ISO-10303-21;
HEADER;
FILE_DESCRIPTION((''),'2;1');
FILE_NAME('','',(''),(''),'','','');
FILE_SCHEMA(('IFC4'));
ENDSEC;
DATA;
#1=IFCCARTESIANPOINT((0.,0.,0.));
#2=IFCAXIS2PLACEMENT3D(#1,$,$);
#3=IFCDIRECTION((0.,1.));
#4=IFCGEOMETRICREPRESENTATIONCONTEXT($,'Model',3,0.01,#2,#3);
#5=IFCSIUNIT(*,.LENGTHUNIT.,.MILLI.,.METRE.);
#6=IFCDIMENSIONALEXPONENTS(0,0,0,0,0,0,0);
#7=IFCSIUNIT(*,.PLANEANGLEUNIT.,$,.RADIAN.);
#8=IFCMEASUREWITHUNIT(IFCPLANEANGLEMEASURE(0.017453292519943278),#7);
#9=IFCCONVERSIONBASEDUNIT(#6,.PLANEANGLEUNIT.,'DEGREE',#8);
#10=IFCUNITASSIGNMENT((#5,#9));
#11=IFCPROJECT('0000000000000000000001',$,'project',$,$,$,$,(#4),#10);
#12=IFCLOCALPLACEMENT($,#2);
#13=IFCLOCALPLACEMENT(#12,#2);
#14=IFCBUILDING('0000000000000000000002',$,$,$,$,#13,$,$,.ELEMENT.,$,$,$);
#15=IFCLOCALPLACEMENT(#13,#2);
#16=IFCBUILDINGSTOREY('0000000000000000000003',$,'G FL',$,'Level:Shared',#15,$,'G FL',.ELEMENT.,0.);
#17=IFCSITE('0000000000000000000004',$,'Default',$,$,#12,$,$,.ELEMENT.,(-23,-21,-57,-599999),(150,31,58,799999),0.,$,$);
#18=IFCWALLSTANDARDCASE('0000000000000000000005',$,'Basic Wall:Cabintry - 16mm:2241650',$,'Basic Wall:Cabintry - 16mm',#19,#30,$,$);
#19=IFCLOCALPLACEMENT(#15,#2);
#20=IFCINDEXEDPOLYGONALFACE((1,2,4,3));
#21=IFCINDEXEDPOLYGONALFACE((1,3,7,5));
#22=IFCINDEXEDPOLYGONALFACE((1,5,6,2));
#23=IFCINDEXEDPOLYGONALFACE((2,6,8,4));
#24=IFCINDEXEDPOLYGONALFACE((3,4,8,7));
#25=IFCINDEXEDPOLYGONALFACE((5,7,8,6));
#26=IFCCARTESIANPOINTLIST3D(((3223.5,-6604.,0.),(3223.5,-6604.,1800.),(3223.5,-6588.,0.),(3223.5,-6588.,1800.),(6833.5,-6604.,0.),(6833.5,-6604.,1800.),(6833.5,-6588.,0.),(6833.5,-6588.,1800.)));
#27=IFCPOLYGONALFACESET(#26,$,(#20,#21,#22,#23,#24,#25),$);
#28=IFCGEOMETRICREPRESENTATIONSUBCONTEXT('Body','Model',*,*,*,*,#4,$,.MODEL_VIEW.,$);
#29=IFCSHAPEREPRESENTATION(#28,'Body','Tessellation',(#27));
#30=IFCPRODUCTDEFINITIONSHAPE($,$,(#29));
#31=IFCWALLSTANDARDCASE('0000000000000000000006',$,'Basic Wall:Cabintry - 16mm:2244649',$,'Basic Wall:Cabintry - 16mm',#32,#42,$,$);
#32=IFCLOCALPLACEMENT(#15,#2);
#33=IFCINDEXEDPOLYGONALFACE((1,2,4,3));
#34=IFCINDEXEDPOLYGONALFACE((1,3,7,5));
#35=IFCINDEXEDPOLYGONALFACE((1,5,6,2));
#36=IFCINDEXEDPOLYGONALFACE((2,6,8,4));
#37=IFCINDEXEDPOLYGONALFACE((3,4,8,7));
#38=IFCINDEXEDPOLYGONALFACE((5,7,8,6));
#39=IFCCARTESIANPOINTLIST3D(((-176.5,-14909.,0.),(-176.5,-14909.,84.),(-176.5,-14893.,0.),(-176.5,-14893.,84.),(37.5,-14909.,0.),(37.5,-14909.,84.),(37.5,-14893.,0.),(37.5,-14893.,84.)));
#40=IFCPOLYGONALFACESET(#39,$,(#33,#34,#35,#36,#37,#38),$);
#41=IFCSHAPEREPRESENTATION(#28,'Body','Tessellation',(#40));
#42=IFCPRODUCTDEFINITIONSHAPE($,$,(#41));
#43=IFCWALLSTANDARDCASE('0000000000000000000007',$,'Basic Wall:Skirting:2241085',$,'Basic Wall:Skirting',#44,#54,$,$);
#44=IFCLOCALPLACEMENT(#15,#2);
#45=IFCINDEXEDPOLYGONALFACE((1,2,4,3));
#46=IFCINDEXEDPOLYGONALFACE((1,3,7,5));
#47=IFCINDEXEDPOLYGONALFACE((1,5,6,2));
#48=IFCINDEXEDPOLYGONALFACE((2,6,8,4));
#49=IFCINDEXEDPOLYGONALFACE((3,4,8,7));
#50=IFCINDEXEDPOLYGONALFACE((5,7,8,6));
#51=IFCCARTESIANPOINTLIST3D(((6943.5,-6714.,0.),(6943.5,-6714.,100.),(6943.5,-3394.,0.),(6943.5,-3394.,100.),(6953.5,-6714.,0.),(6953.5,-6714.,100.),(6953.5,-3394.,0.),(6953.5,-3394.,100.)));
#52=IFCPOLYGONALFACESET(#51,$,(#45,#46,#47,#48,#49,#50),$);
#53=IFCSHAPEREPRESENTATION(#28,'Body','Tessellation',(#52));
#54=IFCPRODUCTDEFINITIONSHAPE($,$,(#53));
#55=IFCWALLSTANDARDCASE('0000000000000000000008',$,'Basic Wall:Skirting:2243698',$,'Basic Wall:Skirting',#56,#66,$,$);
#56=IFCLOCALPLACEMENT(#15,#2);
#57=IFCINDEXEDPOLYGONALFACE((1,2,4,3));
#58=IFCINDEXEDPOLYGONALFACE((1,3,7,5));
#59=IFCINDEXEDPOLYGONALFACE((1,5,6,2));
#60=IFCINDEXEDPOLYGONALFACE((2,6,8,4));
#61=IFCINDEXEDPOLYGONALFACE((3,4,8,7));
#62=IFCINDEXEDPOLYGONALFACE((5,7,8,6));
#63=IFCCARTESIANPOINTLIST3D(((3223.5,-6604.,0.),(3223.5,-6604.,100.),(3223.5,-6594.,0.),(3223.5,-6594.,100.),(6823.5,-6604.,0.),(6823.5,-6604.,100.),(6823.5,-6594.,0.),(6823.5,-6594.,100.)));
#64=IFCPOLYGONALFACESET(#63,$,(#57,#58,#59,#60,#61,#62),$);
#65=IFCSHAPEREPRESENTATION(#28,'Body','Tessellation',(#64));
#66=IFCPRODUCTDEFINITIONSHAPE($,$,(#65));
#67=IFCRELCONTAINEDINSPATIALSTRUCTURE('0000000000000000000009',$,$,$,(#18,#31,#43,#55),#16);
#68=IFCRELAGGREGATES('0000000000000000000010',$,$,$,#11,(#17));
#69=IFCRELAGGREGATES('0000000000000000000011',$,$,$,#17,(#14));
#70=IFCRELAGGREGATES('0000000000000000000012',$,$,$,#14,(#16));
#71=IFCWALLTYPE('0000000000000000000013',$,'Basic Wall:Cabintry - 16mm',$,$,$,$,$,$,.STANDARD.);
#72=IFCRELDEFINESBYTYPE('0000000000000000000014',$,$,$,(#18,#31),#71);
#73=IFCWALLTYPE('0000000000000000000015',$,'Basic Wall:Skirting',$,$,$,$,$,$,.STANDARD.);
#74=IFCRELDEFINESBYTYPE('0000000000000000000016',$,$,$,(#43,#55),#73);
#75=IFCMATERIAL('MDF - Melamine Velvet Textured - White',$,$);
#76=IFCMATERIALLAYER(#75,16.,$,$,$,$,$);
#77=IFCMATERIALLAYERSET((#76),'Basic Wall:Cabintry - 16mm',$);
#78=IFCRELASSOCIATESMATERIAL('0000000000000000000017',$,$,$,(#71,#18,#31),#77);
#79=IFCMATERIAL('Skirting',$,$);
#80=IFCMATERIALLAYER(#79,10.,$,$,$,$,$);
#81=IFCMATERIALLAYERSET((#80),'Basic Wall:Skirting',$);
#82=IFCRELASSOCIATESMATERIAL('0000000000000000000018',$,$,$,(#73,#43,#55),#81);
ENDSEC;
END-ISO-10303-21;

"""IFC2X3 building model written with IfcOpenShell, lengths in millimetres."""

from ifc_helpers import new_model, entity, si_unit, converted_unit, direction, frame, frame_2d, origin, place, context, subcontext, project, spatial, polyline, rectangle, extrude, clip, bounded_halfspace, material, layer, layer_set, layer_usage, type_object, element, save


model = new_model("IFC2X3")

# Units and contexts
model_context = context("Model", 3, precision=0.01, world=origin(), true_north=direction((0.0, 1.0)))
body_context = subcontext(model_context, "Body", "Model", "MODEL_VIEW")
ifc_project = project(units=[si_unit("LENGTHUNIT", "METRE", prefix="MILLI"), converted_unit("PLANEANGLEUNIT", "DEGREE", entity("IfcPlaneAngleMeasure", 0.017453292519943278), si_unit("PLANEANGLEUNIT", "RADIAN"), dimensions=[0, 0, 0, 0, 0, 0, 0])], contexts=[model_context])

# Site, building, storey
site_placement = place(None, origin())
site = spatial("IfcSite", under=ifc_project, at=site_placement, Name="Default", CompositionType="ELEMENT", RefLatitude=(-23, -21, -57, -599999), RefLongitude=(150, 31, 58, 799999), RefElevation=0.0)
building_placement = place(site_placement, origin())
building = spatial("IfcBuilding", under=site, at=building_placement, CompositionType="ELEMENT")
storey_placement = place(building_placement, origin())
storey = spatial("IfcBuildingStorey", under=building, at=storey_placement, Name="G FL", ObjectType="Level:Shared", LongName="G FL", CompositionType="ELEMENT", Elevation=0.0)

# Walls
ifc_material_1 = material(Name="MDF - Melamine Velvet Textured - White")
ifc_layer_1 = layer(ifc_material_1, 16.0)
ifc_layer_set_1 = layer_set([ifc_layer_1], Name="Basic Wall:Cabintry - 16mm")
wall_type_1 = type_object("IfcWallType", Name="Basic Wall:Cabintry - 16mm", PredefinedType="STANDARD", material=ifc_layer_set_1)
ifc_layer_usage_1 = layer_usage(ifc_layer_set_1, "AXIS2", "NEGATIVE", 8.0)
wall_1_placement = place(storey_placement, frame((3223.5, -6596.0, 0.0)))
element("IfcWallStandardCase", 1, at=wall_1_placement, inside=storey, type_object=wall_type_1, material=ifc_layer_usage_1, Name="Basic Wall:Cabintry - 16mm:2241650", ObjectType="Basic Wall:Cabintry - 16mm", context=body_context, shape_type="SweptSolid", body=[
    extrude(rectangle(XDim=3610.0, YDim=16.0, at=frame_2d((1805.0, 0.0), x_axis=(-1.0, 0.0))), origin(), (0.0, 0.0, 1.0), 1800.0),
])
ifc_layer_usage_2 = layer_usage(ifc_layer_set_1, "AXIS2", "POSITIVE", -8.0)
wall_2_placement = place(storey_placement, frame((37.5, -14901.0, 0.0), z_axis=(0.0, 0.0, 1.0), x_axis=(-1.0, 0.0, 0.0)))
element("IfcWallStandardCase", 2, at=wall_2_placement, inside=storey, type_object=wall_type_1, material=ifc_layer_usage_2, Name="Basic Wall:Cabintry - 16mm:2244649", ObjectType="Basic Wall:Cabintry - 16mm", context=body_context, shape_type="Clipping", body=[
    clip(extrude(rectangle(XDim=214.0, YDim=16.0, at=frame_2d((107.0, 0.0), x_axis=(-1.0, 0.0))), origin(), (0.0, 0.0, 1.0), 84.0), bounded_halfspace(frame((0.0, -8.0, 84.0), z_axis=(0.0, 0.0, -1.0), x_axis=(0.0, 1.0, 0.0)), True, frame((0.0, -8.0, 84.0)), polyline([(0.0, 0.0), (214.0, 0.0), (214.0, 16.0), (0.0, 16.0), (0.0, 0.0)]))),
])
ifc_material_2 = material(Name="Skirting")
ifc_layer_2 = layer(ifc_material_2, 10.0)
ifc_layer_set_2 = layer_set([ifc_layer_2], Name="Basic Wall:Skirting")
ifc_layer_usage_3 = layer_usage(ifc_layer_set_2, "AXIS2", "NEGATIVE", 5.0)
wall_type_2 = type_object("IfcWallType", Name="Basic Wall:Skirting", PredefinedType="STANDARD", material=ifc_layer_set_2)
wall_3_placement = place(storey_placement, frame((6948.5, -6714.0, 0.0), z_axis=(0.0, 0.0, 1.0), x_axis=(0.0, 1.0, 0.0)))
element("IfcWallStandardCase", 3, at=wall_3_placement, inside=storey, type_object=wall_type_2, material=ifc_layer_usage_3, Name="Basic Wall:Skirting:2241085", ObjectType="Basic Wall:Skirting", context=body_context, shape_type="SweptSolid", body=[
    extrude(rectangle(XDim=3320.0, YDim=10.0, at=frame_2d((1660.0, 0.0), x_axis=(-1.0, 0.0))), origin(), (0.0, 0.0, 1.0), 100.0),
])
ifc_layer_usage_4 = layer_usage(ifc_layer_set_2, "AXIS2", "NEGATIVE", 5.0)
wall_4_placement = place(storey_placement, frame((6823.5, -6599.0, 0.0), z_axis=(0.0, 0.0, 1.0), x_axis=(-1.0, 0.0, 0.0)))
element("IfcWallStandardCase", 4, at=wall_4_placement, inside=storey, type_object=wall_type_2, material=ifc_layer_usage_4, Name="Basic Wall:Skirting:2243698", ObjectType="Basic Wall:Skirting", context=body_context, shape_type="SweptSolid", body=[
    extrude(rectangle(XDim=3600.0, YDim=10.0, at=frame_2d((1800.0, 0.0), x_axis=(-1.0, 0.0))), origin(), (0.0, 0.0, 1.0), 100.0),
])

save(model, "model.ifc")
